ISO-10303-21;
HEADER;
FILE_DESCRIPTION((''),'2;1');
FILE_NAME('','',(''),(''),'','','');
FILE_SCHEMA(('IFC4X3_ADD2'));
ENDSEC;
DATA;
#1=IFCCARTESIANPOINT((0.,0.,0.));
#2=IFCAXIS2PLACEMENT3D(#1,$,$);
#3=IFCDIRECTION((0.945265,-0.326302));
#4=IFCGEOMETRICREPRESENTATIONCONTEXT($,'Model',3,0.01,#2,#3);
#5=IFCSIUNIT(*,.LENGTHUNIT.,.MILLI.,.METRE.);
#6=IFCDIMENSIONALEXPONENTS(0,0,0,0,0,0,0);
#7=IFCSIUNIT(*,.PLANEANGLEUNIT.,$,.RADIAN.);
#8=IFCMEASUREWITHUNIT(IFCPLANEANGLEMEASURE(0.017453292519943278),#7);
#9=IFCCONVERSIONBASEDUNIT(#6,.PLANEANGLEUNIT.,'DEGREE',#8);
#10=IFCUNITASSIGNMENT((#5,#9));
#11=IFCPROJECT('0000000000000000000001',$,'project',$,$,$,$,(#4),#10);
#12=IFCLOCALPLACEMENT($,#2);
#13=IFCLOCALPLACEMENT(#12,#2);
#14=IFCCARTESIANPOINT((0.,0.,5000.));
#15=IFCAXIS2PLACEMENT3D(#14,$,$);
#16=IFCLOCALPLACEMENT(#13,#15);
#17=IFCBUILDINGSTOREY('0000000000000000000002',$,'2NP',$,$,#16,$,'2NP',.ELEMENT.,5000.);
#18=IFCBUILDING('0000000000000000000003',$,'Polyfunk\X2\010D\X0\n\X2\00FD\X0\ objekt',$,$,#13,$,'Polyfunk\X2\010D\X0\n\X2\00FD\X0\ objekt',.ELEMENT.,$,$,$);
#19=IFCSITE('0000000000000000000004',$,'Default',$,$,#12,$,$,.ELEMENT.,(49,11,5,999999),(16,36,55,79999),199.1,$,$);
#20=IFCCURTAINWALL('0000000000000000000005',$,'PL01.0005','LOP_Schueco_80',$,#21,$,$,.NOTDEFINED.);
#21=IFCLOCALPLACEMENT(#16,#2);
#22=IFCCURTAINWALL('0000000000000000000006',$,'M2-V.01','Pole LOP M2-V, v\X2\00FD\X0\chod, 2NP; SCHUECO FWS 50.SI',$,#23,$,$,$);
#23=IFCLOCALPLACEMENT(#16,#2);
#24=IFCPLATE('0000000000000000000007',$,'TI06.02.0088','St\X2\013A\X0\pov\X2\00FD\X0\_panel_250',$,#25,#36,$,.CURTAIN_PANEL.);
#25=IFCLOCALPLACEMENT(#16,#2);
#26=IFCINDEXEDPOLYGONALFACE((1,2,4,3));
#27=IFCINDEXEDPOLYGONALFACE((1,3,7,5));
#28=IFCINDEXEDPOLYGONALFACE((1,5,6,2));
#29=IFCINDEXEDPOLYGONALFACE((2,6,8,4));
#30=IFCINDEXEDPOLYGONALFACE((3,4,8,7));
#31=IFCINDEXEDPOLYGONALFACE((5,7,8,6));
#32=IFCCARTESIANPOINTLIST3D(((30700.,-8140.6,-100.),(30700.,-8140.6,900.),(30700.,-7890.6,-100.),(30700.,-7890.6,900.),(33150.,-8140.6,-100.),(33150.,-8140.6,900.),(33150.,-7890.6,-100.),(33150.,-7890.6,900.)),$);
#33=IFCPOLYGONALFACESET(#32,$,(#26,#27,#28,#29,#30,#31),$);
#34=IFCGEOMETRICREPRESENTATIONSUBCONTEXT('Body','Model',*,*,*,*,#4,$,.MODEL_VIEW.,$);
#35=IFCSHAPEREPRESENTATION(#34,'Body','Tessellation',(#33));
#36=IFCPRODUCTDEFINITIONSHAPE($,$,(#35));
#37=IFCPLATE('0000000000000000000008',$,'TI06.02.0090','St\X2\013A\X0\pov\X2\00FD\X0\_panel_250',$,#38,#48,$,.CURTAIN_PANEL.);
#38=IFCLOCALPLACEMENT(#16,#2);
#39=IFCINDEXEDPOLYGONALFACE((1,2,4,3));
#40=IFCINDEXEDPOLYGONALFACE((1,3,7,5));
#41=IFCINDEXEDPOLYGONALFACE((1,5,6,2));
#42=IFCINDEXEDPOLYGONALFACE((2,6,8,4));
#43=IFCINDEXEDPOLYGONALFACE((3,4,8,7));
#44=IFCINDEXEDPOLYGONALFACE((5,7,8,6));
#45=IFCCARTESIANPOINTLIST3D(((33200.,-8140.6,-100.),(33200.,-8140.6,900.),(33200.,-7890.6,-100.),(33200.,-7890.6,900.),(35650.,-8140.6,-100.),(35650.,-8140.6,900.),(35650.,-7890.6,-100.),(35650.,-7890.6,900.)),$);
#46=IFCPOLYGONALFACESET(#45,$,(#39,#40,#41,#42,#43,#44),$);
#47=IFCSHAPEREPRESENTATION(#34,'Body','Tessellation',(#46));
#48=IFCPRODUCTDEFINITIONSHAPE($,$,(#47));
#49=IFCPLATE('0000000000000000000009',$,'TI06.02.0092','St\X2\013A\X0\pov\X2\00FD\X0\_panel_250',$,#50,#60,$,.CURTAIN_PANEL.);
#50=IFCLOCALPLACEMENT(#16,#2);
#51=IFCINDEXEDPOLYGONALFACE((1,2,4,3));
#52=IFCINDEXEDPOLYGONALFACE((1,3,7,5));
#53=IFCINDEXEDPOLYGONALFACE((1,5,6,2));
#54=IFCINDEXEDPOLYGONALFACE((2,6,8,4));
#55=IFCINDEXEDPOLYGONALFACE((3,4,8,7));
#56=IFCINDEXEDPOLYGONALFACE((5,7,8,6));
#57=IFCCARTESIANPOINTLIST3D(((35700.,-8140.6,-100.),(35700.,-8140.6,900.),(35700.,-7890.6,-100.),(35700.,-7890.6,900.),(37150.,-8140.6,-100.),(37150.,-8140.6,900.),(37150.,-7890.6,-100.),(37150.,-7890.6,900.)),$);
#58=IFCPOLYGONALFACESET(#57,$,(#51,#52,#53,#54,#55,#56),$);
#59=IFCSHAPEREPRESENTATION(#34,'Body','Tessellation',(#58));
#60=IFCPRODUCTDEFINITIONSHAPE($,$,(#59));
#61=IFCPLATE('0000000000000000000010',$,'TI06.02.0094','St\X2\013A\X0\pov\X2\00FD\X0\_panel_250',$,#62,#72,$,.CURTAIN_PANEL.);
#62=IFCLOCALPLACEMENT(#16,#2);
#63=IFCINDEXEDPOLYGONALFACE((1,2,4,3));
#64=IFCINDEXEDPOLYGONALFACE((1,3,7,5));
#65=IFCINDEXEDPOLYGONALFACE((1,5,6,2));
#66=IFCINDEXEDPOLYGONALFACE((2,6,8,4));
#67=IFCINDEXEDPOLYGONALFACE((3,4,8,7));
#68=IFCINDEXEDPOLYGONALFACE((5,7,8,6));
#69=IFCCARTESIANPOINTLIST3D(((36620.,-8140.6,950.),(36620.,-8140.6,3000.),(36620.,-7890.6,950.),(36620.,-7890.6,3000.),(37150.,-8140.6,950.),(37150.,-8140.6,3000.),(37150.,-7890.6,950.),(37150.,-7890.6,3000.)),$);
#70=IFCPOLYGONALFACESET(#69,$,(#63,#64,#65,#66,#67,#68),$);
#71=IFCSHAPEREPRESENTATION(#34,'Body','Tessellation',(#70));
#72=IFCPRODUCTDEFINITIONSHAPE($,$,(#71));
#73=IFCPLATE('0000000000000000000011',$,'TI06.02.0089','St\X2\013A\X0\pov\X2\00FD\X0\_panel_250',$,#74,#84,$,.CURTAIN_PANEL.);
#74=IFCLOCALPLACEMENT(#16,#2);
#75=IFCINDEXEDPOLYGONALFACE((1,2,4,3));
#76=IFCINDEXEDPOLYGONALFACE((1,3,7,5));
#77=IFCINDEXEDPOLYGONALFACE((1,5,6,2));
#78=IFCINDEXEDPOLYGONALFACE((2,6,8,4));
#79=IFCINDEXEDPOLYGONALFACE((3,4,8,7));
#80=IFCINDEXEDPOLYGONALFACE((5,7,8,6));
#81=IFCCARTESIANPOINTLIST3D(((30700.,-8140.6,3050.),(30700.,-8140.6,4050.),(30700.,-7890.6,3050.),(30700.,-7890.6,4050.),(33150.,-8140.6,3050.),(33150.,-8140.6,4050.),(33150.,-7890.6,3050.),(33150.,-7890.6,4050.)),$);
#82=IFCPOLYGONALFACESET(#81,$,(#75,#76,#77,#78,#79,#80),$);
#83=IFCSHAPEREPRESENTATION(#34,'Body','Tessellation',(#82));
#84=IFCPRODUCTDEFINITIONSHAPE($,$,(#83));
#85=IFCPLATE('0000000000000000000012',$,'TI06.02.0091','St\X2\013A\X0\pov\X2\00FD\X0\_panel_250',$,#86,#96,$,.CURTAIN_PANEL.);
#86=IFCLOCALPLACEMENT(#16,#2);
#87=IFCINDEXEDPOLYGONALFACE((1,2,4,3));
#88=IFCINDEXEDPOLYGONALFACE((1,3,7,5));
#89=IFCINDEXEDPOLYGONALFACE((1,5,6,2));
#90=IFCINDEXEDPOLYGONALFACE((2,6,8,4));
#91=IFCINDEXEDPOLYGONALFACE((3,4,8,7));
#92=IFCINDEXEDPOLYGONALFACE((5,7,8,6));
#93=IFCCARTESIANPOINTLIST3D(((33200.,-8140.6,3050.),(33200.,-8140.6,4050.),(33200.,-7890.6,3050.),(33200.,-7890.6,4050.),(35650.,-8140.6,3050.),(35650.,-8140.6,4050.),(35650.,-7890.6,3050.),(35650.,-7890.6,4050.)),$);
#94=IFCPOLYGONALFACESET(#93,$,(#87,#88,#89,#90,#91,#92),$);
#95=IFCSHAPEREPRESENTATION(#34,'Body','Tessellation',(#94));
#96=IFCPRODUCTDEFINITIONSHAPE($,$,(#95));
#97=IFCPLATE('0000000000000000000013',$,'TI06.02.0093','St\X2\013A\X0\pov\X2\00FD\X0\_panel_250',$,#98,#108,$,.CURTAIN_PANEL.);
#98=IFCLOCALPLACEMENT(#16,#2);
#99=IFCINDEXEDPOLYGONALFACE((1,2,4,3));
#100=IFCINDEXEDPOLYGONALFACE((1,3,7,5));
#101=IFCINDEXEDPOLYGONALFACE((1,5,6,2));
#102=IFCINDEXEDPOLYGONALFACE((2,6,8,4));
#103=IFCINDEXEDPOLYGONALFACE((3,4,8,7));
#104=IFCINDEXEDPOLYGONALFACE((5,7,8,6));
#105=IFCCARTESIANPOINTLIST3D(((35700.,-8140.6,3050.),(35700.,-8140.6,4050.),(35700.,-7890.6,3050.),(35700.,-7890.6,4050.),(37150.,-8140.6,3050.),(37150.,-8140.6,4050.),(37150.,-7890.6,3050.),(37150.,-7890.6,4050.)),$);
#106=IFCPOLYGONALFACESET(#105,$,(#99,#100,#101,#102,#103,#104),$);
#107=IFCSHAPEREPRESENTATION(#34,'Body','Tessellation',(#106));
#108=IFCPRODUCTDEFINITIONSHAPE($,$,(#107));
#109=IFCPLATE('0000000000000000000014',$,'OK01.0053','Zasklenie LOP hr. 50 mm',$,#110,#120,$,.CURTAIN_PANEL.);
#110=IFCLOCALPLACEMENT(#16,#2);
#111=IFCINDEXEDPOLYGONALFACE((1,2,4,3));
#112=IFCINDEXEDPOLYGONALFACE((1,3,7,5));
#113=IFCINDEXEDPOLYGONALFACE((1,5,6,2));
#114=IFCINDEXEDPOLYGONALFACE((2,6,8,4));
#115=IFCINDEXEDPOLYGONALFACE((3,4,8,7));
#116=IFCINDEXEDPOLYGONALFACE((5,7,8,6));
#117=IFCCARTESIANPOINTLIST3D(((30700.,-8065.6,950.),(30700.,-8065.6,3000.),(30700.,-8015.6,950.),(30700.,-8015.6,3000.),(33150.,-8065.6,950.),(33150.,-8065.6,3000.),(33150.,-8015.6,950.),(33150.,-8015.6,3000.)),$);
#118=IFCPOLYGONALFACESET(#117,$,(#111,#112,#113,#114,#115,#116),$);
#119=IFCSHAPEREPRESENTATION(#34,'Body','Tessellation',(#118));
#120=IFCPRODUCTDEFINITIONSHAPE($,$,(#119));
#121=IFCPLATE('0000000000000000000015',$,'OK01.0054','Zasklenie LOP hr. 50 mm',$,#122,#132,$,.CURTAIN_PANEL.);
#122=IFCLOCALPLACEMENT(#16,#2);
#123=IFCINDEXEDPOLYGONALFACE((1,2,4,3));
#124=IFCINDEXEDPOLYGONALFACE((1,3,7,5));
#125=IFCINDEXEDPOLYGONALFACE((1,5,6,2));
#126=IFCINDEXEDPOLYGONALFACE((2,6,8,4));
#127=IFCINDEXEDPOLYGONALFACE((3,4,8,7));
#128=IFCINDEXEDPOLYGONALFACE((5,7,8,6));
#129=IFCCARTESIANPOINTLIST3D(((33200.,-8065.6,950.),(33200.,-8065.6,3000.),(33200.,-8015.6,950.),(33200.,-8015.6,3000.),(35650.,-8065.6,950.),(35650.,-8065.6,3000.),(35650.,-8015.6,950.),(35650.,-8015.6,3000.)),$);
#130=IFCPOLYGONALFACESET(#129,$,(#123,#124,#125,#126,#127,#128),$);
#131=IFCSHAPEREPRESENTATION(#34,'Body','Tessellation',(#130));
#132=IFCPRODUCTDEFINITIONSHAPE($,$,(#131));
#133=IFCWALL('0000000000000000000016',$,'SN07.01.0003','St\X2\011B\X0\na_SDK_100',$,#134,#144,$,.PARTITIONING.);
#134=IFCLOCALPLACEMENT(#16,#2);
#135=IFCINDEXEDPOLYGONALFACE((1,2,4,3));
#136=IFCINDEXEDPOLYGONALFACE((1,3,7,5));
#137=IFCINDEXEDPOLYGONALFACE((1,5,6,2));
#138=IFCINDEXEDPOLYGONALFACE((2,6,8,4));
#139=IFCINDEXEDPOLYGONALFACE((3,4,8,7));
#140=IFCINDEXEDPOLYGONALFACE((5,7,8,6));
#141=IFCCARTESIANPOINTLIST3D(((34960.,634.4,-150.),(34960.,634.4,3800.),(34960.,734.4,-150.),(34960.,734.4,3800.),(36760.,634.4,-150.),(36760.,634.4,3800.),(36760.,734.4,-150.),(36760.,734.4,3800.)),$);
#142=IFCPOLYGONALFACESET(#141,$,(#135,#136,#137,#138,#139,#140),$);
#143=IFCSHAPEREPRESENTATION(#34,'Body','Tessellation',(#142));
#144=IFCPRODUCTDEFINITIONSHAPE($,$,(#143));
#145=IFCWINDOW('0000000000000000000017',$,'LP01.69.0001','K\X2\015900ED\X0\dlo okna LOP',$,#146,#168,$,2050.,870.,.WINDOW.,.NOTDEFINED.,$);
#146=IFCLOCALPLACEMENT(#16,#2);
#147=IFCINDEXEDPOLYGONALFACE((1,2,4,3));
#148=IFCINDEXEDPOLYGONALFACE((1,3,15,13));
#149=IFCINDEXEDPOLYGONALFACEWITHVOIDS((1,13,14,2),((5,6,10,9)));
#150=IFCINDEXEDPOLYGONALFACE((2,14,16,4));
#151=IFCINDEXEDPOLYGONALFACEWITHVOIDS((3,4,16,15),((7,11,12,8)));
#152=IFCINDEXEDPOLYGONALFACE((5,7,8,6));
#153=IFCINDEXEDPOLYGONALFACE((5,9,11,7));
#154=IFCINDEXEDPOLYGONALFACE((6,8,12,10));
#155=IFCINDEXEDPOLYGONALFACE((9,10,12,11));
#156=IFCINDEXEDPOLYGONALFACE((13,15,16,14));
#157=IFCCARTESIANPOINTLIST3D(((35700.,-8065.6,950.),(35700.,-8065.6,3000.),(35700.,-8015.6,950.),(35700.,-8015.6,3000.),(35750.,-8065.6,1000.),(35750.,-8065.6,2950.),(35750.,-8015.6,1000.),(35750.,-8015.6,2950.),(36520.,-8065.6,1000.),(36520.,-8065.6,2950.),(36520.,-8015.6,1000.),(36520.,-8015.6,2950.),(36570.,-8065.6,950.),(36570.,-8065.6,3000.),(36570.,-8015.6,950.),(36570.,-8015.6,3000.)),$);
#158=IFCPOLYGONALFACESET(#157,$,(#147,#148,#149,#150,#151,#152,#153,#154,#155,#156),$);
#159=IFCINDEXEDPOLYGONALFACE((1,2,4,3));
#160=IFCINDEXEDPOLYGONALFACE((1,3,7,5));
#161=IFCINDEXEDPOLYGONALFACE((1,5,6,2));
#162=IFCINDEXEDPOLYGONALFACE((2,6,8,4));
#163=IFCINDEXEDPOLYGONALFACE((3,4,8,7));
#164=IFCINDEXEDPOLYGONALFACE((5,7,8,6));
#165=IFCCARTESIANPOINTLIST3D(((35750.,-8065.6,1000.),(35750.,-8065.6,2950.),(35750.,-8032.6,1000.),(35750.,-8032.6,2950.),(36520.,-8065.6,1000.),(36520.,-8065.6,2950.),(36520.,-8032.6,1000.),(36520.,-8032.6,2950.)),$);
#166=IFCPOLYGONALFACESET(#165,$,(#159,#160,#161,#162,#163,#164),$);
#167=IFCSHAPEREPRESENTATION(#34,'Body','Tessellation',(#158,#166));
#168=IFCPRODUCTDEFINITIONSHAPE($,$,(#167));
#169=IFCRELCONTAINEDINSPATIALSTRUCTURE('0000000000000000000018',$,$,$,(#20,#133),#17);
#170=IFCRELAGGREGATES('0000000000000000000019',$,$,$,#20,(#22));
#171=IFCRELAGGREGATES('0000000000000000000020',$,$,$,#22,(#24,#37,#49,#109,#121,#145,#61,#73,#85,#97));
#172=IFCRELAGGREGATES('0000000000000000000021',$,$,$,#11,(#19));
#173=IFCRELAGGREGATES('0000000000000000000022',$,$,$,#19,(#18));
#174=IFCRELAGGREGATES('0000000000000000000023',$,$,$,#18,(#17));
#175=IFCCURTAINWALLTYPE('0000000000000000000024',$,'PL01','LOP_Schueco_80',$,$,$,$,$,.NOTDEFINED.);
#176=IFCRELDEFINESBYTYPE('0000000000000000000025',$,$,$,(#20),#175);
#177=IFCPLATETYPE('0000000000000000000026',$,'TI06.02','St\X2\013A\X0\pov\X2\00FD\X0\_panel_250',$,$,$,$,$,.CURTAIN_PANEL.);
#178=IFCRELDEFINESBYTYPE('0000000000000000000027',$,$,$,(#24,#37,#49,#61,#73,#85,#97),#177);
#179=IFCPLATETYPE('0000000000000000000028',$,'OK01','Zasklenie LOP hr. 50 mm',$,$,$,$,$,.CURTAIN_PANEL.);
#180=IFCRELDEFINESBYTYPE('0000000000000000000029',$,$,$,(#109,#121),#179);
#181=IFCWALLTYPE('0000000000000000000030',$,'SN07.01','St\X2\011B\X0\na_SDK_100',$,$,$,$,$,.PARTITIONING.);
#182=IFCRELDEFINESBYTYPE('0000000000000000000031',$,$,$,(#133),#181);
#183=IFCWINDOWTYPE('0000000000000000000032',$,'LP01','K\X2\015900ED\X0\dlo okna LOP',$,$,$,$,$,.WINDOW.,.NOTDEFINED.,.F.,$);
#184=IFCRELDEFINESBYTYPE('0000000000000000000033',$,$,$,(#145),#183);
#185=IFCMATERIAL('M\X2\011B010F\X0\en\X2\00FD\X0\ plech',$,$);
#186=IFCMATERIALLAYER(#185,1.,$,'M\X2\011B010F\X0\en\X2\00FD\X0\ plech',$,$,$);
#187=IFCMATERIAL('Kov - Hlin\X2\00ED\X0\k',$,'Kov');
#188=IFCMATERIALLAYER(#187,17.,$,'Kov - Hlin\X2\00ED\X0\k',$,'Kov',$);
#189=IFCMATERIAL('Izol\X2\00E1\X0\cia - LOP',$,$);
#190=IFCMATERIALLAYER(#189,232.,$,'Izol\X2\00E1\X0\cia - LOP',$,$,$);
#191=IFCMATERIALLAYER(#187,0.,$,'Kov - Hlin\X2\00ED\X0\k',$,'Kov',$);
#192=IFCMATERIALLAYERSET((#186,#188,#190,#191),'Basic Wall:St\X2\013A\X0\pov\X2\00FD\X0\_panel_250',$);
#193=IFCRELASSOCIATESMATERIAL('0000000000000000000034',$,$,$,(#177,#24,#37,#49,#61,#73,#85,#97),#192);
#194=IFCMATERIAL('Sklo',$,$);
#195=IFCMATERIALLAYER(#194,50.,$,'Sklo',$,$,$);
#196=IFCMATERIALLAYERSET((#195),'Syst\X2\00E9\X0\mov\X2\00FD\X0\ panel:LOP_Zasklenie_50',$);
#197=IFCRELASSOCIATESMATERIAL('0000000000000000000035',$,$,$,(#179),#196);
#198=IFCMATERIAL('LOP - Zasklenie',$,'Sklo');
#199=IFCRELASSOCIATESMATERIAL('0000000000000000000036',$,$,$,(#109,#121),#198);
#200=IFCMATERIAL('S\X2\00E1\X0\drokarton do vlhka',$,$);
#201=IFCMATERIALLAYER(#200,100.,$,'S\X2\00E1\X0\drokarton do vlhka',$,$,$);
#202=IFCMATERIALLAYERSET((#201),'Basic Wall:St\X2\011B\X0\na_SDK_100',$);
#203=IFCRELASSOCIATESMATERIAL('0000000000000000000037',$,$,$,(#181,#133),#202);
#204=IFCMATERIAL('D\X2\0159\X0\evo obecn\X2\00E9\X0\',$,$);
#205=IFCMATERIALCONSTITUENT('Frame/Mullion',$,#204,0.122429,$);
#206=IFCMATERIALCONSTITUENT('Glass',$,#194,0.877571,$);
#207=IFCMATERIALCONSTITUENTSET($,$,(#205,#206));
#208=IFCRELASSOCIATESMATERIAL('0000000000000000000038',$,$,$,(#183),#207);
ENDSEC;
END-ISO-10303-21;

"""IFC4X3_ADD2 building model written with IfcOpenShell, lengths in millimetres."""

from ifc_helpers import new_model, entity, si_unit, converted_unit, direction, frame, frame_2d, origin, origin_2d_with_axis, place, context, subcontext, project, spatial, polyline, rectangle, outline, extrude, clip, bounded_halfspace, source, transform, mapped, material, layer, layer_set, layer_usage, constituent, constituent_set, type_object, type_shapes, element, aggregate, save


model = new_model("IFC4X3_ADD2")

# Units and contexts
model_context = context("Model", 3, precision=0.01, world=origin(), true_north=direction((0.945265, -0.326302)))
body_context = subcontext(model_context, "Body", "Model", "MODEL_VIEW")
ifc_project = project(units=[si_unit("LENGTHUNIT", "METRE", prefix="MILLI"), converted_unit("PLANEANGLEUNIT", "DEGREE", entity("IfcPlaneAngleMeasure", 0.017453292519943278), si_unit("PLANEANGLEUNIT", "RADIAN"), dimensions=[0, 0, 0, 0, 0, 0, 0])], contexts=[model_context])

# Site, building, storey
site_placement = place(None, origin())
site = spatial("IfcSite", under=ifc_project, at=site_placement, Name="Default", CompositionType="ELEMENT", RefLatitude=(49, 11, 5, 999999), RefLongitude=(16, 36, 55, 79999), RefElevation=199.1)
building_placement = place(site_placement, origin())
building = spatial("IfcBuilding", under=site, at=building_placement, Name="Polyfunkčný objekt", LongName="Polyfunkčný objekt", CompositionType="ELEMENT")
storey_placement = place(building_placement, frame((0.0, 0.0, 5000.0)))
storey = spatial("IfcBuildingStorey", under=building, at=storey_placement, Name="2NP", LongName="2NP", CompositionType="ELEMENT", Elevation=5000.0)

# Curtain walls, plates
curtain_wall_type = type_object("IfcCurtainWallType", Name="PL01", Description="LOP_Schueco_80", PredefinedType="NOTDEFINED")
curtain_wall_1_placement = place(storey_placement, frame((0.0, 0.0, -5000.0)))
curtain_wall_1 = element("IfcCurtainWall", 1, at=curtain_wall_1_placement, inside=storey, type_object=curtain_wall_type, Name="PL01.0005", Description="LOP_Schueco_80", PredefinedType="NOTDEFINED")
curtain_wall_2 = element("IfcCurtainWall", 2, Name="M2-V.01", Description="Pole LOP M2-V, východ, 2NP; SCHUECO FWS 50.SI")
aggregate(curtain_wall_1, [curtain_wall_2])
ifc_material_1 = material(Name="Měďený plech")
ifc_layer_1 = layer(ifc_material_1, 1.0, Name="Měďený plech")
ifc_material_2 = material(Name="Kov - Hliník", Category="Kov")
ifc_layer_2 = layer(ifc_material_2, 17.0, Name="Kov - Hliník", Category="Kov")
ifc_material_3 = material(Name="Izolácia - LOP")
ifc_layer_3 = layer(ifc_material_3, 232.0, Name="Izolácia - LOP")
ifc_layer_4 = layer(ifc_material_2, 0.0, Name="Kov - Hliník", Category="Kov")
ifc_layer_set_1 = layer_set([ifc_layer_1, ifc_layer_2, ifc_layer_3, ifc_layer_4], Name="Basic Wall:Stĺpový_panel_250")
ifc_layer_usage_1 = layer_usage(ifc_layer_set_1, "AXIS2", "POSITIVE", -125.0)
plate_type_1 = type_object("IfcPlateType", Name="TI06.02", Description="Stĺpový_panel_250", PredefinedType="CURTAIN_PANEL", material=ifc_layer_set_1)
plate_1_placement = place(storey_placement, frame((30700.0, -8015.6, -100.0)))
plate_1 = element("IfcPlate", 3, at=plate_1_placement, type_object=plate_type_1, material=ifc_layer_usage_1, Name="TI06.02.0088", Description="Stĺpový_panel_250", PredefinedType="CURTAIN_PANEL", context=body_context, shape_type="SweptSolid", body=[
    extrude(rectangle(XDim=250.0, YDim=2450.0, at=frame_2d((0.0, 0.0), x_axis=(1.0, 0.0))), frame((1225.0, 0.0, 0.0), z_axis=(0.0, 0.0, 1.0), x_axis=(0.0, 1.0, 0.0)), (0.0, 0.0, 1.0), 1000.0),
])
ifc_layer_usage_2 = layer_usage(ifc_layer_set_1, "AXIS2", "POSITIVE", -125.0)
plate_2_placement = place(storey_placement, frame((33200.0, -8015.6, -100.0)))
plate_2 = element("IfcPlate", 4, at=plate_2_placement, type_object=plate_type_1, material=ifc_layer_usage_2, Name="TI06.02.0090", Description="Stĺpový_panel_250", PredefinedType="CURTAIN_PANEL", context=body_context, shape_type="SweptSolid", body=[
    extrude(rectangle(XDim=250.0, YDim=2450.0, at=frame_2d((0.0, 0.0), x_axis=(1.0, 0.0))), frame((1225.0, 0.0, 0.0), z_axis=(0.0, 0.0, 1.0), x_axis=(0.0, 1.0, 0.0)), (0.0, 0.0, 1.0), 1000.0),
])
ifc_layer_usage_3 = layer_usage(ifc_layer_set_1, "AXIS2", "POSITIVE", -125.0)
plate_3_placement = place(storey_placement, frame((35700.0, -8015.6, -100.0)))
plate_3 = element("IfcPlate", 5, at=plate_3_placement, type_object=plate_type_1, material=ifc_layer_usage_3, Name="TI06.02.0092", Description="Stĺpový_panel_250", PredefinedType="CURTAIN_PANEL", context=body_context, shape_type="SweptSolid", body=[
    extrude(rectangle(XDim=250.0, YDim=1450.0, at=frame_2d((0.0, 0.0), x_axis=(1.0, 0.0))), frame((725.0, 0.0, 0.0), z_axis=(0.0, 0.0, 1.0), x_axis=(0.0, 1.0, 0.0)), (0.0, 0.0, 1.0), 1000.0),
])
ifc_layer_usage_4 = layer_usage(ifc_layer_set_1, "AXIS2", "POSITIVE", -125.0)
plate_4_placement = place(storey_placement, frame((36620.0, -8015.6, 950.0)))
plate_4 = element("IfcPlate", 6, at=plate_4_placement, type_object=plate_type_1, material=ifc_layer_usage_4, Name="TI06.02.0094", Description="Stĺpový_panel_250", PredefinedType="CURTAIN_PANEL", context=body_context, shape_type="SweptSolid", body=[
    extrude(rectangle(XDim=250.0, YDim=530.0, at=frame_2d((0.0, 0.0), x_axis=(1.0, 0.0))), frame((265.0, 0.0, 0.0), z_axis=(0.0, 0.0, 1.0), x_axis=(0.0, 1.0, 0.0)), (0.0, 0.0, 1.0), 2050.0),
])
ifc_layer_usage_5 = layer_usage(ifc_layer_set_1, "AXIS2", "POSITIVE", -125.0)
plate_5_placement = place(storey_placement, frame((30700.0, -8015.6, 3050.0)))
plate_5 = element("IfcPlate", 7, at=plate_5_placement, type_object=plate_type_1, material=ifc_layer_usage_5, Name="TI06.02.0089", Description="Stĺpový_panel_250", PredefinedType="CURTAIN_PANEL", context=body_context, shape_type="SweptSolid", body=[
    extrude(rectangle(XDim=250.0, YDim=2450.0, at=frame_2d((0.0, 0.0), x_axis=(1.0, 0.0))), frame((1225.0, 0.0, 0.0), z_axis=(0.0, 0.0, 1.0), x_axis=(0.0, 1.0, 0.0)), (0.0, 0.0, 1.0), 1000.0),
])
ifc_layer_usage_6 = layer_usage(ifc_layer_set_1, "AXIS2", "POSITIVE", -125.0)
plate_6_placement = place(storey_placement, frame((33200.0, -8015.6, 3050.0)))
plate_6 = element("IfcPlate", 8, at=plate_6_placement, type_object=plate_type_1, material=ifc_layer_usage_6, Name="TI06.02.0091", Description="Stĺpový_panel_250", PredefinedType="CURTAIN_PANEL", context=body_context, shape_type="SweptSolid", body=[
    extrude(rectangle(XDim=250.0, YDim=2450.0, at=frame_2d((0.0, 0.0), x_axis=(1.0, 0.0))), frame((1225.0, 0.0, 0.0), z_axis=(0.0, 0.0, 1.0), x_axis=(0.0, 1.0, 0.0)), (0.0, 0.0, 1.0), 1000.0),
])
ifc_layer_usage_7 = layer_usage(ifc_layer_set_1, "AXIS2", "POSITIVE", -125.0)
plate_7_placement = place(storey_placement, frame((35700.0, -8015.6, 3050.0)))
plate_7 = element("IfcPlate", 9, at=plate_7_placement, type_object=plate_type_1, material=ifc_layer_usage_7, Name="TI06.02.0093", Description="Stĺpový_panel_250", PredefinedType="CURTAIN_PANEL", context=body_context, shape_type="SweptSolid", body=[
    extrude(rectangle(XDim=250.0, YDim=1450.0, at=frame_2d((0.0, 0.0), x_axis=(1.0, 0.0))), frame((725.0, 0.0, 0.0), z_axis=(0.0, 0.0, 1.0), x_axis=(0.0, 1.0, 0.0)), (0.0, 0.0, 1.0), 1000.0),
])
ifc_material_4 = material(Name="LOP - Zasklenie", Category="Sklo")
ifc_material_5 = material(Name="Sklo")
ifc_layer_5 = layer(ifc_material_5, 50.0, Name="Sklo")
ifc_layer_set_2 = layer_set([ifc_layer_5], Name="Systémový panel:LOP_Zasklenie_50")
plate_type_2 = type_object("IfcPlateType", Name="OK01", Description="Zasklenie LOP hr. 50 mm", PredefinedType="CURTAIN_PANEL", material=ifc_layer_set_2)
shared_shape_1 = source(origin(), body_context, "Body", "SweptSolid", [
    extrude(rectangle(XDim=50.0, YDim=2450.0, at=origin_2d_with_axis()), frame((0.0, -25.0, 0.0), z_axis=(0.0, 0.0, 1.0), x_axis=(0.0, 1.0, 0.0)), (0.0, 0.0, 1.0), 2050.0),
])
type_shapes(plate_type_2, [shared_shape_1])
plate_8_placement = place(curtain_wall_1_placement, frame((31925.0, -8015.6, 5950.0)))
plate_8 = element("IfcPlate", 10, at=plate_8_placement, type_object=plate_type_2, material=ifc_material_4, Name="OK01.0053", Description="Zasklenie LOP hr. 50 mm", PredefinedType="CURTAIN_PANEL", context=body_context, shape_type="MappedRepresentation", body=[
    mapped(shared_shape_1, transform((0.0, 0.0, 0.0), scale=1.0)),
])
plate_9_placement = place(curtain_wall_1_placement, frame((34425.0, -8015.6, 5950.0)))
plate_9 = element("IfcPlate", 11, at=plate_9_placement, type_object=plate_type_2, material=ifc_material_4, Name="OK01.0054", Description="Zasklenie LOP hr. 50 mm", PredefinedType="CURTAIN_PANEL", context=body_context, shape_type="MappedRepresentation", body=[
    mapped(shared_shape_1, transform((0.0, 0.0, 0.0), scale=1.0)),
])

# Wall
ifc_material_6 = material(Name="Sádrokarton do vlhka")
ifc_layer_6 = layer(ifc_material_6, 100.0, Name="Sádrokarton do vlhka")
ifc_layer_set_3 = layer_set([ifc_layer_6], Name="Basic Wall:Stěna_SDK_100")
wall_type_1 = type_object("IfcWallType", Name="SN07.01", Description="Stěna_SDK_100", PredefinedType="PARTITIONING", material=ifc_layer_set_3)
placement = place(building_placement, origin())
wall_1_placement = place(placement, frame((34960.0, 684.4, 4850.0)))
element("IfcWall", 12, at=wall_1_placement, inside=storey, type_object=wall_type_1, material=ifc_layer_set_3, Name="SN07.01.0003", Description="Stěna_SDK_100", PredefinedType="PARTITIONING", context=body_context, shape_type="Clipping", body=[
    clip(clip(extrude(rectangle(XDim=1800.0, YDim=100.0, at=frame_2d((900.0, 0.0), x_axis=(-1.0, 0.0))), origin(), (0.0, 0.0, 1.0), 3950.0), bounded_halfspace(frame((1800.0, -50.0, 0.0), z_axis=(0.0, 0.0, 1.0), x_axis=(-1.0, 0.0, 0.0)), True, frame((1800.0, -50.0, 0.0)), polyline([(0.0, 0.0), (0.0, 100.0), (-1800.0, 100.0), (-1800.0, 0.0), (0.0, 0.0)]))), bounded_halfspace(frame((0.0, -50.0, 3950.0), z_axis=(0.0, 0.0, -1.0), x_axis=(1.0, 0.0, 0.0)), True, frame((0.0, -50.0, 3950.0)), polyline([(0.0, 0.0), (1800.0, 0.0), (1800.0, 100.0), (0.0, 100.0), (0.0, 0.0)]))),
])

# Window
ifc_material_7 = material(Name="Dřevo obecné")
ifc_constituent_1 = constituent(ifc_material_7, Name="Frame/Mullion", fraction=0.122429)
ifc_constituent_2 = constituent(ifc_material_5, Name="Glass", fraction=0.877571)
ifc_constituent_set = constituent_set(constituents=[ifc_constituent_1, ifc_constituent_2])
window_type = type_object("IfcWindowType", Name="LP01", Description="Křídlo okna LOP", ParameterTakesPrecedence=False, PartitioningType="NOTDEFINED", PredefinedType="WINDOW", material=ifc_constituent_set)
shared_shape_2 = source(origin(), body_context, "Body", "SweptSolid", [
    extrude(outline(polyline([(-1025.0, -435.0), (1025.0, -435.0), (1025.0, 435.0), (-1025.0, 435.0), (-1025.0, -435.0)]), holes=[polyline([(-975.0, -385.0), (-975.0, 385.0), (975.0, 385.0), (975.0, -385.0), (-975.0, -385.0)])]), frame((0.0, 50.0, 1025.0), z_axis=(0.0, -1.0, 0.0), x_axis=(0.0, 0.0, -1.0)), (0.0, 0.0, 1.0), 50.0),
    extrude(rectangle(XDim=770.0, YDim=33.0, at=frame_2d((0.0, 0.0), x_axis=(1.0, 0.0))), frame((0.0, 33.5, 50.0), z_axis=(0.0, 0.0, 1.0), x_axis=(-1.0, 0.0, 0.0)), (0.0, 0.0, 1.0), 1950.0),
])
type_shapes(window_type, [shared_shape_2])
window_placement = place(curtain_wall_1_placement, frame((36135.0, -8015.6, 5950.0), z_axis=(0.0, 0.0, 1.0), x_axis=(-1.0, 0.0, 0.0)))
window = element("IfcWindow", 13, at=window_placement, type_object=window_type, Name="LP01.69.0001", Description="Křídlo okna LOP", OverallHeight=2050.0, OverallWidth=870.0, PartitioningType="NOTDEFINED", PredefinedType="WINDOW", context=body_context, shape_type="MappedRepresentation", body=[
    mapped(shared_shape_2, transform((0.0, 0.0, 0.0), scale=1.0)),
])
aggregate(curtain_wall_2, [plate_1, plate_2, plate_3, plate_8, plate_9, window, plate_4, plate_5, plate_6, plate_7])

save(model, "model.ifc")
